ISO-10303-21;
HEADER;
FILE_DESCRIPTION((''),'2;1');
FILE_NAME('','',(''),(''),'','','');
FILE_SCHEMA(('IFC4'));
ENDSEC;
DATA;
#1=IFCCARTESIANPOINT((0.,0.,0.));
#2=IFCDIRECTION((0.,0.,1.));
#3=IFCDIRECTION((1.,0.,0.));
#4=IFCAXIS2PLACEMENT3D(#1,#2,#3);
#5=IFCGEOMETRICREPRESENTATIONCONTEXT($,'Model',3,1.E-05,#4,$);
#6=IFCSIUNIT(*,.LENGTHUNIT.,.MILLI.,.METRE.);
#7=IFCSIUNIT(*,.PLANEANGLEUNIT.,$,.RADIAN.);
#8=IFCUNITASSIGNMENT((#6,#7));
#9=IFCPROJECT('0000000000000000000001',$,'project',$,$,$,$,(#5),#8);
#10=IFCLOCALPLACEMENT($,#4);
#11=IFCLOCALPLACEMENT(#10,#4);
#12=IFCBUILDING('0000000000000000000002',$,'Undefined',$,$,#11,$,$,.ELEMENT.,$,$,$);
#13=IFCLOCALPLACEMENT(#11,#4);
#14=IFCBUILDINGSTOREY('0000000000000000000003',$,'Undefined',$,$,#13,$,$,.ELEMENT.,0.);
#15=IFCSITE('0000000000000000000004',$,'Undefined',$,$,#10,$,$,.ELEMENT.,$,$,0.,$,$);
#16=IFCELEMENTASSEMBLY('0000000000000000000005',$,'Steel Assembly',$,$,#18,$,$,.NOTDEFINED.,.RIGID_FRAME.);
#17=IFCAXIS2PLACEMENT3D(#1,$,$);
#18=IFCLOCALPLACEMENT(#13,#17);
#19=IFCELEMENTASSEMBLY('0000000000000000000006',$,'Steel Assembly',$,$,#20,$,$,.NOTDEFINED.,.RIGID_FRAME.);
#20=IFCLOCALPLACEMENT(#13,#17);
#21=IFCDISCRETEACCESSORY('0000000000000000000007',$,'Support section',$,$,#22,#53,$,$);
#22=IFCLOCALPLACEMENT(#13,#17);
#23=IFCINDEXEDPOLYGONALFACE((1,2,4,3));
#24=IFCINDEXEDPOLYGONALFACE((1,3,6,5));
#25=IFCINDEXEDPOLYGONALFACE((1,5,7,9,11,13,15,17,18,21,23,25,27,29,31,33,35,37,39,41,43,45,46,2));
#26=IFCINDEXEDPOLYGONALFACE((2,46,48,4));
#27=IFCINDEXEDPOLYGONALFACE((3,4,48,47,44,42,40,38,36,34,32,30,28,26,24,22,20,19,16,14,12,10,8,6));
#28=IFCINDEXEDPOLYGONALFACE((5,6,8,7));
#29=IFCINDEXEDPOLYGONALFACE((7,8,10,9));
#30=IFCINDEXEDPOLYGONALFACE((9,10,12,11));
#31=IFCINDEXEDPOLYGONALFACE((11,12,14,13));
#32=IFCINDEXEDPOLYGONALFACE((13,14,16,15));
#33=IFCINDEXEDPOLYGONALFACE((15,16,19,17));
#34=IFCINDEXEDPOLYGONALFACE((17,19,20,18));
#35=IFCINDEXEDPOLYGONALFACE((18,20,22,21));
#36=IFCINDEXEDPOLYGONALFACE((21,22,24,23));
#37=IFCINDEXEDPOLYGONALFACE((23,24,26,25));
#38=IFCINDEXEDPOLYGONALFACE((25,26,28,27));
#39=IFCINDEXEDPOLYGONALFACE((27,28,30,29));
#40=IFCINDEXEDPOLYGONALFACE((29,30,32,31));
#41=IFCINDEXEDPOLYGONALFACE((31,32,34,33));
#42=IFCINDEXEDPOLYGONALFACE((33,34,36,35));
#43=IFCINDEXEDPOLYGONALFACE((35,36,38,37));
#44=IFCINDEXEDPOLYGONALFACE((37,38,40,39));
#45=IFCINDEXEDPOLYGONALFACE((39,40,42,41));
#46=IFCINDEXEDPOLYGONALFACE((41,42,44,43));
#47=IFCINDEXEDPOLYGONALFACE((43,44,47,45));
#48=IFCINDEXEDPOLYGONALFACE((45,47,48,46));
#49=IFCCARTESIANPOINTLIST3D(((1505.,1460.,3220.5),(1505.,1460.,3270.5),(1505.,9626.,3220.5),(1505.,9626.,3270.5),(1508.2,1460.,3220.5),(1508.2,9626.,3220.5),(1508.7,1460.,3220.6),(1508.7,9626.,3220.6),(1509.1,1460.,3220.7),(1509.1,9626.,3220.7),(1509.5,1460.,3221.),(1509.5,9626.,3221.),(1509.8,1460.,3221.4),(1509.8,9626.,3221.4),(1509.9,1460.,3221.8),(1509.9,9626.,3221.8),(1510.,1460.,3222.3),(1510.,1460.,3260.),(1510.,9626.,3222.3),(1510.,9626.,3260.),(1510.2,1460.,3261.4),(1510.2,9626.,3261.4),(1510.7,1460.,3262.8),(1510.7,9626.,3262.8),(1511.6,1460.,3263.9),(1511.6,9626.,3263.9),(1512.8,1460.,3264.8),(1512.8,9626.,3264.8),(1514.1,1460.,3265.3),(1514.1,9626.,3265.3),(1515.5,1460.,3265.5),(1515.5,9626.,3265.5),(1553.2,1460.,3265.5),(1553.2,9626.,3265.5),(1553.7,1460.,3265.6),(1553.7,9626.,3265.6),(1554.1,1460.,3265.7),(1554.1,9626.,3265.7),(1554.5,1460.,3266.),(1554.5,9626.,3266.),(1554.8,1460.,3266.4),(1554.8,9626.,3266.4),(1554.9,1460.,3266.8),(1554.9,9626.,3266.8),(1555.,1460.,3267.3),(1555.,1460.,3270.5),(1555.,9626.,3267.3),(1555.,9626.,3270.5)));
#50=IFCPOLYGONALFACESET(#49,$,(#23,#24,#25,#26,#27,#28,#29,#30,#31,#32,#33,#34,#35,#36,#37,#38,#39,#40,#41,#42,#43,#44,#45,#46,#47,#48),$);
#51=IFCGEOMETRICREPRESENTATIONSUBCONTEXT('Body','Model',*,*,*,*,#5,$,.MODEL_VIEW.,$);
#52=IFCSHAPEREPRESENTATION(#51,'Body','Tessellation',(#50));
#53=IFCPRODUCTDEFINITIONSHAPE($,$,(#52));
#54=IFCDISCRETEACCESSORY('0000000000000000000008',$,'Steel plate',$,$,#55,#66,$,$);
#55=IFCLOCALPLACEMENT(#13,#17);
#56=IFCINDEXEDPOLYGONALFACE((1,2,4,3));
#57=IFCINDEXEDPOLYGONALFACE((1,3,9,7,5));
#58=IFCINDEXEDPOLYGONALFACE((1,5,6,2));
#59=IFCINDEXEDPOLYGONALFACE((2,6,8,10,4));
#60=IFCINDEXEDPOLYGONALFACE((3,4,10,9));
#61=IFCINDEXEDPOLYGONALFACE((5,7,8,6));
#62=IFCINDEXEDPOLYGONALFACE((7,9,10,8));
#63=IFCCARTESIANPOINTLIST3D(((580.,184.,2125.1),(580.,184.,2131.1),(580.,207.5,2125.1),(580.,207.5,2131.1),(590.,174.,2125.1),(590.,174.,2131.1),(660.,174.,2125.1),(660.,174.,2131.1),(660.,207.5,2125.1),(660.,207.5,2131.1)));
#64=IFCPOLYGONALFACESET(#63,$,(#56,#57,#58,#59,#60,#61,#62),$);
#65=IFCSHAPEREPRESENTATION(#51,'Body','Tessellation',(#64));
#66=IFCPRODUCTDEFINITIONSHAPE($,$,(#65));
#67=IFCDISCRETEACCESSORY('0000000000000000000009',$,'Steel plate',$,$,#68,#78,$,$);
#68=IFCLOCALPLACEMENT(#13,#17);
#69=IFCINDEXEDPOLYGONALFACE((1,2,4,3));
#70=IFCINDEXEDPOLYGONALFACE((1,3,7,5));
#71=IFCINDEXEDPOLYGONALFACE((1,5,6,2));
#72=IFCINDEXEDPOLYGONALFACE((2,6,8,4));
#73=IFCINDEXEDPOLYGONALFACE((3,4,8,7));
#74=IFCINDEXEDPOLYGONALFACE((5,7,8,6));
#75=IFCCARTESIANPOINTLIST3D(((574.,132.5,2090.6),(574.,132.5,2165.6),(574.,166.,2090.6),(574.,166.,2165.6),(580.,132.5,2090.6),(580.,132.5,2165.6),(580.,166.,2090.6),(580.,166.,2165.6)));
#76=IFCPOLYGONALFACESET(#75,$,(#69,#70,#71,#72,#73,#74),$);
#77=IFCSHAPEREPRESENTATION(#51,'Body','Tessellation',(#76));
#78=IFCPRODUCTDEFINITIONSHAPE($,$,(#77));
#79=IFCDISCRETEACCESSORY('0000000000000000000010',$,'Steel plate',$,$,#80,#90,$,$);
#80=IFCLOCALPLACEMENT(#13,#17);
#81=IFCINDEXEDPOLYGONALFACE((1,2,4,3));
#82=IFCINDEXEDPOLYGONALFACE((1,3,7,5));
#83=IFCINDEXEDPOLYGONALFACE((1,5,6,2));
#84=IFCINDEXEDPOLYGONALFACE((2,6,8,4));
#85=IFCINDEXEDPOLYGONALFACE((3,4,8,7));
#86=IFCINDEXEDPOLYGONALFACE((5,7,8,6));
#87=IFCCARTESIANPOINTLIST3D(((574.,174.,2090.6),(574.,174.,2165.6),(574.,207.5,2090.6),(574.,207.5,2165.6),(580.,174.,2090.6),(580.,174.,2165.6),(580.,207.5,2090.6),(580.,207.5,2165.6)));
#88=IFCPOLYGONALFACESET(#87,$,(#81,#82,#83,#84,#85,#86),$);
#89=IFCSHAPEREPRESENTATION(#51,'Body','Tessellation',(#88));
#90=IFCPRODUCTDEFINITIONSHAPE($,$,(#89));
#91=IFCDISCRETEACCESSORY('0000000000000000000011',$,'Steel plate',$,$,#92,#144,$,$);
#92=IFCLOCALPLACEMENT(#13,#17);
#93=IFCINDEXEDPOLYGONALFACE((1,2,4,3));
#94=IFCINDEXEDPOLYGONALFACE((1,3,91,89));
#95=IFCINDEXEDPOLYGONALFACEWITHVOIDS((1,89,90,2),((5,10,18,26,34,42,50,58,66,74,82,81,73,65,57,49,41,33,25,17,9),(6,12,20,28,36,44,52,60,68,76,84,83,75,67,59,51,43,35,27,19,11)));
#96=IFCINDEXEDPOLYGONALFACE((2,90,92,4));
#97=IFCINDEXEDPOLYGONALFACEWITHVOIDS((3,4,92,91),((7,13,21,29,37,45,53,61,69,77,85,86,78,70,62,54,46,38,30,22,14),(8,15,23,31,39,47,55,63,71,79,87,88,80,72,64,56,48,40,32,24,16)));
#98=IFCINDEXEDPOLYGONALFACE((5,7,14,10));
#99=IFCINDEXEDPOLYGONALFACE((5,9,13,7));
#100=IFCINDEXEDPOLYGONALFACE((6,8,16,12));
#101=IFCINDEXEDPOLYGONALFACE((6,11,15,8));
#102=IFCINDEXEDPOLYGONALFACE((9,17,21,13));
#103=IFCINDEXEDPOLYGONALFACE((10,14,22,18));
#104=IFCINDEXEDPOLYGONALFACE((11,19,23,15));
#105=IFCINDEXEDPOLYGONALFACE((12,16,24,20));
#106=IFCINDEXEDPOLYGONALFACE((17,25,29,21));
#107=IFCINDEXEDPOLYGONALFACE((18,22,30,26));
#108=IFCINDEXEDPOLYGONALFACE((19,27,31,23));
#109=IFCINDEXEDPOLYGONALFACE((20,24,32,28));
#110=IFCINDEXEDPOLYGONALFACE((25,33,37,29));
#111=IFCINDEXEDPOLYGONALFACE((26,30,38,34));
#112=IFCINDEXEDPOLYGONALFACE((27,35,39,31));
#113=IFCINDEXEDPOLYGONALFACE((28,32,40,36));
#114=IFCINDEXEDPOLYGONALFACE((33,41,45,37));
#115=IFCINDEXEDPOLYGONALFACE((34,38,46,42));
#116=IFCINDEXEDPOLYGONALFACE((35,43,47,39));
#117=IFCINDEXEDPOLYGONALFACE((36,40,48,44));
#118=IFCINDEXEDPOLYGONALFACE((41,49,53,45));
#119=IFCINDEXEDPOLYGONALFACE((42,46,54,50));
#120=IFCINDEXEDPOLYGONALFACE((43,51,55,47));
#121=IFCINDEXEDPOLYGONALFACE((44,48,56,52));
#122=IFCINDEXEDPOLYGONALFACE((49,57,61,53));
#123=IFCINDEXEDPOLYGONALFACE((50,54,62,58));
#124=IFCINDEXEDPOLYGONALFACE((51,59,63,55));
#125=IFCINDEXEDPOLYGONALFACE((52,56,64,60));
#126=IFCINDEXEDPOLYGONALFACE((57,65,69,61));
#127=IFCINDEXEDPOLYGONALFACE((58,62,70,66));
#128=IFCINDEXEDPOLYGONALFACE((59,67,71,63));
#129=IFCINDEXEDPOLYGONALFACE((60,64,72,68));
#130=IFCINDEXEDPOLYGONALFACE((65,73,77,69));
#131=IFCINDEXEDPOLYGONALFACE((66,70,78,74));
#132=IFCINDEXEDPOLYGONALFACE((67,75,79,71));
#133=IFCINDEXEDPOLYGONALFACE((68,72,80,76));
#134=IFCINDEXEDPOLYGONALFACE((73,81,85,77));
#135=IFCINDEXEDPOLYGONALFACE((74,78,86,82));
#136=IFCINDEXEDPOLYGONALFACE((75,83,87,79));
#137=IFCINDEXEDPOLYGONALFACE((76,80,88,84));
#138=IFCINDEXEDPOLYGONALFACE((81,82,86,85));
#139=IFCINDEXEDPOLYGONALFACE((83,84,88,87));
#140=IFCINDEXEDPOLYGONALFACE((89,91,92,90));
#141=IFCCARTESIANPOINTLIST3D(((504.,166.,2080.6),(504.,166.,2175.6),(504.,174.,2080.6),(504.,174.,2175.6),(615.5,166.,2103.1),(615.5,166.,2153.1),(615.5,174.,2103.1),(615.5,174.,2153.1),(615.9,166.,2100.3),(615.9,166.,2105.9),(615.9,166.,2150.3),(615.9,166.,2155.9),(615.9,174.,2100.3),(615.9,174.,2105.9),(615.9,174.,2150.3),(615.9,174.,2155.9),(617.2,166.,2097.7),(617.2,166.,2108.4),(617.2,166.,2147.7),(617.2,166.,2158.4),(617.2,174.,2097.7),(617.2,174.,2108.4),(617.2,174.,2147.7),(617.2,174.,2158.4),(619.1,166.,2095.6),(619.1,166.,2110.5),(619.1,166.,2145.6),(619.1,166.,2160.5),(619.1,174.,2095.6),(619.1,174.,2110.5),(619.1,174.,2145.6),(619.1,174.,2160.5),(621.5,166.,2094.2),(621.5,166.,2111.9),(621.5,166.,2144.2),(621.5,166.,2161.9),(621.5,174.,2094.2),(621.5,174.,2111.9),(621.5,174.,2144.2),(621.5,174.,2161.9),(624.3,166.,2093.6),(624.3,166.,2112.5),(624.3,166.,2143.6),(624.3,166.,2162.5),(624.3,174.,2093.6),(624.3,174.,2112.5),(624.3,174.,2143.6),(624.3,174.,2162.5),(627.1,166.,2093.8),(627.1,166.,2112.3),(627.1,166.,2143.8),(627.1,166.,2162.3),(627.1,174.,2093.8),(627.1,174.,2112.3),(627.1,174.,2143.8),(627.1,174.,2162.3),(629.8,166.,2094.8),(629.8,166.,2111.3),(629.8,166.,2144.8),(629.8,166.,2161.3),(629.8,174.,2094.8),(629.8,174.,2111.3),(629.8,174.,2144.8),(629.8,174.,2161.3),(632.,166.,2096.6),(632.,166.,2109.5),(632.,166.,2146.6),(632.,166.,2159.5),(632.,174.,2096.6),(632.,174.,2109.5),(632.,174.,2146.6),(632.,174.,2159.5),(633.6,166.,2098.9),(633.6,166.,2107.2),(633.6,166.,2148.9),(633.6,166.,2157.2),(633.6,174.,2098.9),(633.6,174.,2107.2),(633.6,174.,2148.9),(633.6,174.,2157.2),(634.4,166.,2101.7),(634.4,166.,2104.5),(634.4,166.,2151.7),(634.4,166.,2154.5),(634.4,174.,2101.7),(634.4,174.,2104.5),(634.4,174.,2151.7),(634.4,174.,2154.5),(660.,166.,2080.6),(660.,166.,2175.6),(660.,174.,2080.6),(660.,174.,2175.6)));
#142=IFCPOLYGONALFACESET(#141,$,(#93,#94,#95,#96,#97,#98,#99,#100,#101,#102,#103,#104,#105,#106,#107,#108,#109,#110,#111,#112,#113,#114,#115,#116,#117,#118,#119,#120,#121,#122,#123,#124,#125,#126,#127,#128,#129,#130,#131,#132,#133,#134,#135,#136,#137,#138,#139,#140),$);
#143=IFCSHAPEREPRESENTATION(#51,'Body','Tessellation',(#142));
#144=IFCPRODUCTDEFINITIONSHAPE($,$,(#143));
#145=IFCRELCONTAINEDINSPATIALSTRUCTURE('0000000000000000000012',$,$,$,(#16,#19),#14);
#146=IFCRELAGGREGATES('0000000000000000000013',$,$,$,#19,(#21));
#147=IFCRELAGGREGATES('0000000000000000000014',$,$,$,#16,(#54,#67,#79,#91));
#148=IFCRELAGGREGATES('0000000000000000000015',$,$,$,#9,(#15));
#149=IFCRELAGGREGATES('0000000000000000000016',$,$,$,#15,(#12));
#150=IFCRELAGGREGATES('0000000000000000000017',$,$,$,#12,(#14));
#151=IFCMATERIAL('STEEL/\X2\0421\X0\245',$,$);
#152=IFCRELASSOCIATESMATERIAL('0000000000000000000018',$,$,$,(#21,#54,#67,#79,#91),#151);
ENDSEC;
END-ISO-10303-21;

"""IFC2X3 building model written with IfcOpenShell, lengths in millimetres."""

from ifc_helpers import new_model, si_unit, frame, origin_with_axes, origin_2d_with_axis, place, context, subcontext, project, spatial, polyline, circle, l_section, outline, extrude, source, transform, mapped, material, element, aggregate, save


model = new_model("IFC2X3")

# Units and contexts
model_context = context("Model", 3, precision=1e-05, world=origin_with_axes())
body_context = subcontext(model_context, "Body", "Model", "MODEL_VIEW")
ifc_project = project(units=[si_unit("LENGTHUNIT", "METRE", prefix="MILLI"), si_unit("PLANEANGLEUNIT", "RADIAN")], contexts=[model_context])

# Site, building, storey
site_placement = place(None, origin_with_axes())
site = spatial("IfcSite", under=ifc_project, at=site_placement, Name="Undefined", CompositionType="ELEMENT", RefElevation=0.0)
building_placement = place(site_placement, origin_with_axes())
building = spatial("IfcBuilding", under=site, at=building_placement, Name="Undefined", CompositionType="ELEMENT")
storey_placement = place(building_placement, origin_with_axes())
storey = spatial("IfcBuildingStorey", under=building, at=storey_placement, Name="Undefined", CompositionType="ELEMENT", Elevation=0.0)

# Shared definitions
ifc_material_1 = material(Name="STEEL/С245")

# Element assembly
assembly_1_placement = place(storey_placement, origin_with_axes())
assembly_1 = element("IfcElementAssembly", 1, at=assembly_1_placement, inside=storey, Name="Steel Assembly", AssemblyPlace="NOTDEFINED", PredefinedType="RIGID_FRAME")

# Element assembly, discrete accessory
assembly_2_placement = place(storey_placement, origin_with_axes())
assembly_2 = element("IfcElementAssembly", 2, at=assembly_2_placement, inside=storey, Name="Steel Assembly", AssemblyPlace="NOTDEFINED", PredefinedType="RIGID_FRAME")
discrete_accessory_1_placement = place(assembly_2_placement, frame((1530.0, 1460.0, 3245.5), z_axis=(1.0, 0.0, 0.0), x_axis=(0.0, 1.0, 0.0)))
discrete_accessory_1 = element("IfcDiscreteAccessory", 3, at=discrete_accessory_1_placement, material=ifc_material_1, Name="Support section", context=body_context, shape_type="SweptSolid", body=[
    extrude(l_section(Depth=50.0, Width=50.0, Thickness=5.0, FilletRadius=5.5, EdgeRadius=1.8, at=origin_2d_with_axis()), frame((8166.0, 0.0, 0.0), z_axis=(-1.0, 0.0, 0.0), x_axis=(0.0, -1.0, 0.0)), (0.0, 0.0, 1.0), 8166.0),
])
aggregate(assembly_2, [discrete_accessory_1])

# Discrete accessory
discrete_accessory_2_placement = place(assembly_1_placement, frame((660.0, 207.5, 2128.1), z_axis=(0.0, 0.0, 1.0), x_axis=(-1.0, 0.0, 0.0)))
discrete_accessory_2 = element("IfcDiscreteAccessory", 4, at=discrete_accessory_2_placement, material=ifc_material_1, Name="Steel plate", context=body_context, shape_type="SweptSolid", body=[
    extrude(outline(polyline([(0.0, 0.0), (80.0, 0.0), (80.0, 23.5), (70.0, 33.5), (0.0, 33.5), (0.0, 0.0)])), frame((0.0, 0.0, -3.0), z_axis=(0.0, 0.0, 1.0), x_axis=(1.0, 0.0, 0.0)), (0.0, 0.0, 1.0), 6.0),
])

# Discrete accessories, openings
discrete_accessory_3_placement = place(assembly_1_placement, frame((577.0, 132.5, 2165.6), z_axis=(1.0, 0.0, 0.0), x_axis=(0.0, 0.0, -1.0)))
discrete_accessory_3 = element("IfcDiscreteAccessory", 5, at=discrete_accessory_3_placement, material=ifc_material_1, Name="Steel plate", context=body_context, shape_type="SweptSolid", body=[
    extrude(outline(polyline([(0.0, 0.0), (75.0, 0.0), (75.0, 75.0), (0.0, 75.0), (0.0, 0.0)])), frame((0.0, 0.0, -3.0), z_axis=(0.0, 0.0, 1.0), x_axis=(1.0, 0.0, 0.0)), (0.0, 0.0, 1.0), 6.0),
])
opening_1_placement = place(assembly_1_placement, frame((577.0, 132.5, 2165.6), z_axis=(1.0, 0.0, 0.0), x_axis=(0.0, 0.0, -1.0)))
element("IfcOpeningElement", 6, at=opening_1_placement, cuts=discrete_accessory_3, ObjectType="Recess", context=body_context, shape_type="SweptSolid", body=[
    extrude(outline(polyline([(0.0, 0.0), (75.0, 0.0), (75.0, 150.0), (0.0, 150.0), (0.0, 0.0)])), frame((112.5, 108.5, 6.0), z_axis=(0.0, 0.0, -1.0), x_axis=(0.0, -1.0, 0.0)), (0.0, 0.0, 1.0), 12.0),
])
discrete_accessory_4_placement = place(assembly_1_placement, frame((577.0, 207.5, 2090.6), z_axis=(1.0, 0.0, 0.0), x_axis=(0.0, 0.0, 1.0)))
discrete_accessory_4 = element("IfcDiscreteAccessory", 7, at=discrete_accessory_4_placement, material=ifc_material_1, Name="Steel plate", context=body_context, shape_type="SweptSolid", body=[
    extrude(outline(polyline([(0.0, 0.0), (75.0, 0.0), (75.0, 75.0), (0.0, 75.0), (0.0, 0.0)])), frame((0.0, 0.0, -3.0), z_axis=(0.0, 0.0, 1.0), x_axis=(1.0, 0.0, 0.0)), (0.0, 0.0, 1.0), 6.0),
])
opening_2_placement = place(assembly_1_placement, frame((577.0, 207.5, 2090.6), z_axis=(1.0, 0.0, 0.0), x_axis=(0.0, 0.0, 1.0)))
element("IfcOpeningElement", 8, at=opening_2_placement, cuts=discrete_accessory_4, ObjectType="Recess", context=body_context, shape_type="SweptSolid", body=[
    extrude(outline(polyline([(0.0, 0.0), (75.0, 0.0), (75.0, 150.0), (0.0, 150.0), (0.0, 0.0)])), frame((112.5, 108.5, 6.0), z_axis=(0.0, 0.0, -1.0), x_axis=(0.0, -1.0, 0.0)), (0.0, 0.0, 1.0), 12.0),
])
discrete_accessory_5_placement = place(assembly_1_placement, frame((660.0, 170.0, 2175.6), z_axis=(0.0, 1.0, 0.0), x_axis=(0.0, 0.0, -1.0)))
discrete_accessory_5 = element("IfcDiscreteAccessory", 9, at=discrete_accessory_5_placement, material=ifc_material_1, Name="Steel plate", context=body_context, shape_type="SweptSolid", body=[
    extrude(outline(polyline([(0.0, 0.0), (95.0, 0.0), (95.0, 156.0), (0.0, 156.0), (0.0, 0.0)])), frame((0.0, 0.0, -4.0), z_axis=(0.0, 0.0, 1.0), x_axis=(1.0, 0.0, 0.0)), (0.0, 0.0, 1.0), 8.0),
])
shared_shape_1 = source(origin_with_axes(), body_context, "Body", "SweptSolid", [
    extrude(circle(Radius=9.5, at=origin_2d_with_axis()), frame((0.0, -4.1, 0.0), z_axis=(0.0, 1.0, 0.0), x_axis=(1.0, 0.0, 0.0)), (0.0, 0.0, 1.0), 12.3),
])
opening_3_placement = place(assembly_1_placement, frame((625.0, 170.0, 2128.1), z_axis=(0.0, 0.0, 1.0), x_axis=(-1.0, 0.0, 0.0)))
element("IfcOpeningElement", 10, at=opening_3_placement, cuts=discrete_accessory_5, ObjectType="Opening", context=body_context, shape_type="MappedRepresentation", body=[
    mapped(shared_shape_1, transform((0.0, 0.0, -25.0))),
    mapped(shared_shape_1, transform((0.0, 0.0, 25.0))),
])
aggregate(assembly_1, [discrete_accessory_2, discrete_accessory_3, discrete_accessory_4, discrete_accessory_5])

save(model, "model.ifc")
